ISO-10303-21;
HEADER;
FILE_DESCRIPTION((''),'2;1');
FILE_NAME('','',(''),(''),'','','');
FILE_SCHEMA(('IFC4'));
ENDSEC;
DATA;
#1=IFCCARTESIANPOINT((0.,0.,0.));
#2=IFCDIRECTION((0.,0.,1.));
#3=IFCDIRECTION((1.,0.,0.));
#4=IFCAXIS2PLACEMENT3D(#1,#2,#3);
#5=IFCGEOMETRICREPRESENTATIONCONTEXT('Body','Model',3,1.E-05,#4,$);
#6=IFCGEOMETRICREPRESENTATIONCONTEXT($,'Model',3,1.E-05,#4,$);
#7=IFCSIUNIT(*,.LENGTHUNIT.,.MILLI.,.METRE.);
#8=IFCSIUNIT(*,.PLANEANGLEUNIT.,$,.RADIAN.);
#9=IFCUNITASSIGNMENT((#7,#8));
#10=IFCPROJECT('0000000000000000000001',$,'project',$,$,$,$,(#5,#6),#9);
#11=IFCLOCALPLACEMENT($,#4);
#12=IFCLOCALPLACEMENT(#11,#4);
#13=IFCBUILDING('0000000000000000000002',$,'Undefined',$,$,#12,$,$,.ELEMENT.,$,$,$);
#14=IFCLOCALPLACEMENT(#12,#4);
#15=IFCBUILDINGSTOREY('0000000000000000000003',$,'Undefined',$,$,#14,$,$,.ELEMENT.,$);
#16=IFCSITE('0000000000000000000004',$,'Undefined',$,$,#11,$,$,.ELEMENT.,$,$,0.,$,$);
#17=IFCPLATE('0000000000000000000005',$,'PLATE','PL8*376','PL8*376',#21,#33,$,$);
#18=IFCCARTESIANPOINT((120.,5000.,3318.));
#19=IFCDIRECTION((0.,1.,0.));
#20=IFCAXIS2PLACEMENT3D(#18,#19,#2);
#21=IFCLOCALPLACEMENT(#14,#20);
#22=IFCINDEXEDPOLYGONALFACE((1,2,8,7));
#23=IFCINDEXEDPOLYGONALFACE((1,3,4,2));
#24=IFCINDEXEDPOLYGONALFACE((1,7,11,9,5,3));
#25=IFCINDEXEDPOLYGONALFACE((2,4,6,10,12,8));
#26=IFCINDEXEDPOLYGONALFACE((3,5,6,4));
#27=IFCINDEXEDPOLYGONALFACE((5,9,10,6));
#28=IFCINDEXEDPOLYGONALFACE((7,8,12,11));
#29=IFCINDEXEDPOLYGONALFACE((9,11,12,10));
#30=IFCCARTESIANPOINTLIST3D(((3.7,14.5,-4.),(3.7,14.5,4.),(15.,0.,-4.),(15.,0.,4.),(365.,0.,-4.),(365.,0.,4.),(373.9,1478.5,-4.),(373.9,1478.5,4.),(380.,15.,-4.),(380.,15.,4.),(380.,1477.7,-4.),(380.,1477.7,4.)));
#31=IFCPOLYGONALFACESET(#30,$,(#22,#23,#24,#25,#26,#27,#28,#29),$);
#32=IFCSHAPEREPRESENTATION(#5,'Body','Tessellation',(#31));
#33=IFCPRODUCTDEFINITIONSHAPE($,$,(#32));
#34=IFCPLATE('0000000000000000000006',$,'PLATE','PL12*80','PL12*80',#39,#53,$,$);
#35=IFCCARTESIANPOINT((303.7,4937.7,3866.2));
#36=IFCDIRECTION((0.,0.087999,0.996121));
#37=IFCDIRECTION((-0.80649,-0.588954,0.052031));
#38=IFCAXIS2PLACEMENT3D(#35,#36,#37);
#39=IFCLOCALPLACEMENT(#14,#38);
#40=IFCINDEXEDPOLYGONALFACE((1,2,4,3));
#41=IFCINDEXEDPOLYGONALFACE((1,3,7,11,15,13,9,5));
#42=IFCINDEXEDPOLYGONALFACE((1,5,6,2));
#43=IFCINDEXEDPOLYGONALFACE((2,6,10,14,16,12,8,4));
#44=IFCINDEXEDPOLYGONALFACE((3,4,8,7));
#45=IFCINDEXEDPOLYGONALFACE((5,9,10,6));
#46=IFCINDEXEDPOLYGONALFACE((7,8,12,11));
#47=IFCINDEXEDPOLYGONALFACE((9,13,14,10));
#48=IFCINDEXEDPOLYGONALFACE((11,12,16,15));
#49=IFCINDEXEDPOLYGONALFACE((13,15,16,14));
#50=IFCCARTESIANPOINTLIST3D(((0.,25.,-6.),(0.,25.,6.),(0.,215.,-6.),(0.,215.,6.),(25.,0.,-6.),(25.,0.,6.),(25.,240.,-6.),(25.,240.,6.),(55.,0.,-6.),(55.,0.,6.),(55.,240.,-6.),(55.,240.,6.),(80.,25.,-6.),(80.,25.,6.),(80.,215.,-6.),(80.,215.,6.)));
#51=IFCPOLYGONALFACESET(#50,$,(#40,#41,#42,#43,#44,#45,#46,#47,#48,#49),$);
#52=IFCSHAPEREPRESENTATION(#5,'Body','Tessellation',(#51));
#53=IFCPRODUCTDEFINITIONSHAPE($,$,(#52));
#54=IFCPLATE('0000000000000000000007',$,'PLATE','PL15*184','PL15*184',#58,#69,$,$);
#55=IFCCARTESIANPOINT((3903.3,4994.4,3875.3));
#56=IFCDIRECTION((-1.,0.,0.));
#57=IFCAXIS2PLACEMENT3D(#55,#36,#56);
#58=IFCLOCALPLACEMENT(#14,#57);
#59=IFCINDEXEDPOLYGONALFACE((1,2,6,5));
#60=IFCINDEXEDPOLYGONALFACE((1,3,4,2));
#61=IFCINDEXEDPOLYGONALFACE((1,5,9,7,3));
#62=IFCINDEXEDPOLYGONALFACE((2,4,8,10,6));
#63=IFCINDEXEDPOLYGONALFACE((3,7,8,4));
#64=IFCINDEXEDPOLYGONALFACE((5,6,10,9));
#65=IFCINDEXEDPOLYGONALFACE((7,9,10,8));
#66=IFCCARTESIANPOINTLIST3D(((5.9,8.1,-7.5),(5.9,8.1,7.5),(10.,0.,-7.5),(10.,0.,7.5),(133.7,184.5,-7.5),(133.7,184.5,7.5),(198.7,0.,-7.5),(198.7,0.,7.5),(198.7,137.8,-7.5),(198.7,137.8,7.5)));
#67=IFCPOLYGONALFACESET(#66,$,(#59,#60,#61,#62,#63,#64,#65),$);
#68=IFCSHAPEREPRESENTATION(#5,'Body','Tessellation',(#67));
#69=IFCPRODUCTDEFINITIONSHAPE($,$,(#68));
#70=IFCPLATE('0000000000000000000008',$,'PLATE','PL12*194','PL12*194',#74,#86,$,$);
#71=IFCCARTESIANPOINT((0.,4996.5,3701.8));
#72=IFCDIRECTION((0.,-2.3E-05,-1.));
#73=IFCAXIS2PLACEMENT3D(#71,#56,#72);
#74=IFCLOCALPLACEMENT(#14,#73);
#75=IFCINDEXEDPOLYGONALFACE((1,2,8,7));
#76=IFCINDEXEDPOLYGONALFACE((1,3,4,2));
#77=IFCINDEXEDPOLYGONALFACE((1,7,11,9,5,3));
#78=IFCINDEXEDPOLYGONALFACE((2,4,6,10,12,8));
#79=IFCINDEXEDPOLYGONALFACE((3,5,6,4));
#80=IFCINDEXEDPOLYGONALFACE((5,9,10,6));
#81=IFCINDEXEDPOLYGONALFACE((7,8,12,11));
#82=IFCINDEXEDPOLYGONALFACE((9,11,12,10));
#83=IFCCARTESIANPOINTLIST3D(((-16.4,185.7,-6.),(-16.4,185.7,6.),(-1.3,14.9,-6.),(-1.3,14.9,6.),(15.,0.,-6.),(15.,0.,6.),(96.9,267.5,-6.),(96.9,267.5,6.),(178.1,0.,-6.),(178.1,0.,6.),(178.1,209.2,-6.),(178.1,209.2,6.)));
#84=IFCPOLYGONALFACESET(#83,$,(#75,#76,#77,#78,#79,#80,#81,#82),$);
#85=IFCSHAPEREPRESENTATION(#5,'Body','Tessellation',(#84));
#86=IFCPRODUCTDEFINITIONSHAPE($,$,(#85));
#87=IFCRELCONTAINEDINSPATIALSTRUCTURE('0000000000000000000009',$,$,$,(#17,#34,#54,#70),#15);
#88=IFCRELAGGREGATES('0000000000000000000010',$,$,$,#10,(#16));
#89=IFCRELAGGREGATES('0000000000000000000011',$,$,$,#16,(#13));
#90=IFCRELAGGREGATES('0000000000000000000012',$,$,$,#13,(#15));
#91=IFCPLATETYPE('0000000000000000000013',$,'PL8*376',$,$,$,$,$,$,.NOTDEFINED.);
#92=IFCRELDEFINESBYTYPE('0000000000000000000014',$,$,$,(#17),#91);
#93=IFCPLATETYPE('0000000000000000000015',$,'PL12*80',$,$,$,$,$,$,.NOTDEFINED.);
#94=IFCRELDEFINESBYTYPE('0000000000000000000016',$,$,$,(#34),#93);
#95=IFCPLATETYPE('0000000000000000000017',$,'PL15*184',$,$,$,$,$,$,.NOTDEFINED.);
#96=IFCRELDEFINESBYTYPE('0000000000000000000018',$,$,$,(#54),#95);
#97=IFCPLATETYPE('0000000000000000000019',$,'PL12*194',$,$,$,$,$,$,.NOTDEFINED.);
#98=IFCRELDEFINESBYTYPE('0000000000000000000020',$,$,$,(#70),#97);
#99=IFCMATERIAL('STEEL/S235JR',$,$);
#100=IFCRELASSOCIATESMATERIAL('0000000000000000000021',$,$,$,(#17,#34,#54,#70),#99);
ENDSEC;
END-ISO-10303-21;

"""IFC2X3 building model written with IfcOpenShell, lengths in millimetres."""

from ifc_helpers import new_model, si_unit, frame, origin_with_axes, place, context, project, spatial, polyline, outline, extrude, material, type_object, element, save


model = new_model("IFC2X3")

# Units and contexts
model_context_1 = context("Model", 3, precision=1e-05, world=origin_with_axes(), identifier="Body")
model_context_2 = context("Model", 3, precision=1e-05, world=origin_with_axes())
ifc_project = project(units=[si_unit("LENGTHUNIT", "METRE", prefix="MILLI"), si_unit("PLANEANGLEUNIT", "RADIAN")], contexts=[model_context_1, model_context_2])

# Site, building, storey
site_placement = place(None, origin_with_axes())
site = spatial("IfcSite", under=ifc_project, at=site_placement, Name="Undefined", CompositionType="ELEMENT", RefElevation=0.0)
building_placement = place(site_placement, origin_with_axes())
building = spatial("IfcBuilding", under=site, at=building_placement, Name="Undefined", CompositionType="ELEMENT")
storey_placement = place(building_placement, origin_with_axes())
storey = spatial("IfcBuildingStorey", under=building, at=storey_placement, Name="Undefined", CompositionType="ELEMENT")

# Shared definitions
ifc_material = material(Name="STEEL/S235JR")

# Plates
plate_type_1 = type_object("IfcPlateType", Name="PL8*376", PredefinedType="NOTDEFINED")
plate_1_placement = place(storey_placement, frame((120.0, 5000.0, 3318.0), z_axis=(0.0, 1.0, 0.0), x_axis=(0.0, 0.0, 1.0)))
element("IfcPlate", 1, at=plate_1_placement, inside=storey, type_object=plate_type_1, material=ifc_material, Name="PLATE", Description="PL8*376", ObjectType="PL8*376", context=model_context_1, shape_type="SweptSolid", body=[
    extrude(outline(polyline([(3.7, 14.5), (15.0, 0.0), (365.0, 0.0), (380.0, 15.0), (380.0, 1477.7), (373.9, 1478.5), (3.7, 14.5)])), frame((0.0, 0.0, -4.0), z_axis=(0.0, 0.0, 1.0), x_axis=(1.0, 0.0, 0.0)), (0.0, 0.0, 1.0), 8.0),
])
plate_type_2 = type_object("IfcPlateType", Name="PL12*80", PredefinedType="NOTDEFINED")
plate_2_placement = place(storey_placement, frame((303.7, 4937.7, 3866.2), z_axis=(0.0, 0.087999, 0.996121), x_axis=(-0.80649, -0.588954, 0.052031)))
element("IfcPlate", 2, at=plate_2_placement, inside=storey, type_object=plate_type_2, material=ifc_material, Name="PLATE", Description="PL12*80", ObjectType="PL12*80", context=model_context_1, shape_type="SweptSolid", body=[
    extrude(outline(polyline([(0.0, 25.0), (25.0, 0.0), (55.0, 0.0), (80.0, 25.0), (80.0, 215.0), (55.0, 240.0), (25.0, 240.0), (0.0, 215.0), (0.0, 25.0)])), frame((0.0, 0.0, -6.0), z_axis=(0.0, 0.0, 1.0), x_axis=(1.0, 0.0, 0.0)), (0.0, 0.0, 1.0), 12.0),
])
plate_type_3 = type_object("IfcPlateType", Name="PL15*184", PredefinedType="NOTDEFINED")
plate_3_placement = place(storey_placement, frame((3903.3, 4994.4, 3875.3), z_axis=(0.0, 0.087999, 0.996121), x_axis=(-1.0, 0.0, 0.0)))
element("IfcPlate", 3, at=plate_3_placement, inside=storey, type_object=plate_type_3, material=ifc_material, Name="PLATE", Description="PL15*184", ObjectType="PL15*184", context=model_context_1, shape_type="SweptSolid", body=[
    extrude(outline(polyline([(5.9, 8.1), (10.0, 0.0), (198.7, 0.0), (198.7, 137.8), (133.7, 184.5), (5.9, 8.1)])), frame((0.0, 0.0, -7.5), z_axis=(0.0, 0.0, 1.0), x_axis=(1.0, 0.0, 0.0)), (0.0, 0.0, 1.0), 15.0),
])
plate_type_4 = type_object("IfcPlateType", Name="PL12*194", PredefinedType="NOTDEFINED")
plate_4_placement = place(storey_placement, frame((0.0, 4996.5, 3701.8), z_axis=(-1.0, 0.0, 0.0), x_axis=(0.0, -0.000023, -1.0)))
element("IfcPlate", 4, at=plate_4_placement, inside=storey, type_object=plate_type_4, material=ifc_material, Name="PLATE", Description="PL12*194", ObjectType="PL12*194", context=model_context_1, shape_type="SweptSolid", body=[
    extrude(outline(polyline([(-1.3, 14.9), (15.0, 0.0), (178.1, 0.0), (178.1, 209.2), (96.9, 267.5), (-16.4, 185.7), (-1.3, 14.9)])), frame((0.0, 0.0, -6.0), z_axis=(0.0, 0.0, 1.0), x_axis=(1.0, 0.0, 0.0)), (0.0, 0.0, 1.0), 12.0),
])

save(model, "model.ifc")
